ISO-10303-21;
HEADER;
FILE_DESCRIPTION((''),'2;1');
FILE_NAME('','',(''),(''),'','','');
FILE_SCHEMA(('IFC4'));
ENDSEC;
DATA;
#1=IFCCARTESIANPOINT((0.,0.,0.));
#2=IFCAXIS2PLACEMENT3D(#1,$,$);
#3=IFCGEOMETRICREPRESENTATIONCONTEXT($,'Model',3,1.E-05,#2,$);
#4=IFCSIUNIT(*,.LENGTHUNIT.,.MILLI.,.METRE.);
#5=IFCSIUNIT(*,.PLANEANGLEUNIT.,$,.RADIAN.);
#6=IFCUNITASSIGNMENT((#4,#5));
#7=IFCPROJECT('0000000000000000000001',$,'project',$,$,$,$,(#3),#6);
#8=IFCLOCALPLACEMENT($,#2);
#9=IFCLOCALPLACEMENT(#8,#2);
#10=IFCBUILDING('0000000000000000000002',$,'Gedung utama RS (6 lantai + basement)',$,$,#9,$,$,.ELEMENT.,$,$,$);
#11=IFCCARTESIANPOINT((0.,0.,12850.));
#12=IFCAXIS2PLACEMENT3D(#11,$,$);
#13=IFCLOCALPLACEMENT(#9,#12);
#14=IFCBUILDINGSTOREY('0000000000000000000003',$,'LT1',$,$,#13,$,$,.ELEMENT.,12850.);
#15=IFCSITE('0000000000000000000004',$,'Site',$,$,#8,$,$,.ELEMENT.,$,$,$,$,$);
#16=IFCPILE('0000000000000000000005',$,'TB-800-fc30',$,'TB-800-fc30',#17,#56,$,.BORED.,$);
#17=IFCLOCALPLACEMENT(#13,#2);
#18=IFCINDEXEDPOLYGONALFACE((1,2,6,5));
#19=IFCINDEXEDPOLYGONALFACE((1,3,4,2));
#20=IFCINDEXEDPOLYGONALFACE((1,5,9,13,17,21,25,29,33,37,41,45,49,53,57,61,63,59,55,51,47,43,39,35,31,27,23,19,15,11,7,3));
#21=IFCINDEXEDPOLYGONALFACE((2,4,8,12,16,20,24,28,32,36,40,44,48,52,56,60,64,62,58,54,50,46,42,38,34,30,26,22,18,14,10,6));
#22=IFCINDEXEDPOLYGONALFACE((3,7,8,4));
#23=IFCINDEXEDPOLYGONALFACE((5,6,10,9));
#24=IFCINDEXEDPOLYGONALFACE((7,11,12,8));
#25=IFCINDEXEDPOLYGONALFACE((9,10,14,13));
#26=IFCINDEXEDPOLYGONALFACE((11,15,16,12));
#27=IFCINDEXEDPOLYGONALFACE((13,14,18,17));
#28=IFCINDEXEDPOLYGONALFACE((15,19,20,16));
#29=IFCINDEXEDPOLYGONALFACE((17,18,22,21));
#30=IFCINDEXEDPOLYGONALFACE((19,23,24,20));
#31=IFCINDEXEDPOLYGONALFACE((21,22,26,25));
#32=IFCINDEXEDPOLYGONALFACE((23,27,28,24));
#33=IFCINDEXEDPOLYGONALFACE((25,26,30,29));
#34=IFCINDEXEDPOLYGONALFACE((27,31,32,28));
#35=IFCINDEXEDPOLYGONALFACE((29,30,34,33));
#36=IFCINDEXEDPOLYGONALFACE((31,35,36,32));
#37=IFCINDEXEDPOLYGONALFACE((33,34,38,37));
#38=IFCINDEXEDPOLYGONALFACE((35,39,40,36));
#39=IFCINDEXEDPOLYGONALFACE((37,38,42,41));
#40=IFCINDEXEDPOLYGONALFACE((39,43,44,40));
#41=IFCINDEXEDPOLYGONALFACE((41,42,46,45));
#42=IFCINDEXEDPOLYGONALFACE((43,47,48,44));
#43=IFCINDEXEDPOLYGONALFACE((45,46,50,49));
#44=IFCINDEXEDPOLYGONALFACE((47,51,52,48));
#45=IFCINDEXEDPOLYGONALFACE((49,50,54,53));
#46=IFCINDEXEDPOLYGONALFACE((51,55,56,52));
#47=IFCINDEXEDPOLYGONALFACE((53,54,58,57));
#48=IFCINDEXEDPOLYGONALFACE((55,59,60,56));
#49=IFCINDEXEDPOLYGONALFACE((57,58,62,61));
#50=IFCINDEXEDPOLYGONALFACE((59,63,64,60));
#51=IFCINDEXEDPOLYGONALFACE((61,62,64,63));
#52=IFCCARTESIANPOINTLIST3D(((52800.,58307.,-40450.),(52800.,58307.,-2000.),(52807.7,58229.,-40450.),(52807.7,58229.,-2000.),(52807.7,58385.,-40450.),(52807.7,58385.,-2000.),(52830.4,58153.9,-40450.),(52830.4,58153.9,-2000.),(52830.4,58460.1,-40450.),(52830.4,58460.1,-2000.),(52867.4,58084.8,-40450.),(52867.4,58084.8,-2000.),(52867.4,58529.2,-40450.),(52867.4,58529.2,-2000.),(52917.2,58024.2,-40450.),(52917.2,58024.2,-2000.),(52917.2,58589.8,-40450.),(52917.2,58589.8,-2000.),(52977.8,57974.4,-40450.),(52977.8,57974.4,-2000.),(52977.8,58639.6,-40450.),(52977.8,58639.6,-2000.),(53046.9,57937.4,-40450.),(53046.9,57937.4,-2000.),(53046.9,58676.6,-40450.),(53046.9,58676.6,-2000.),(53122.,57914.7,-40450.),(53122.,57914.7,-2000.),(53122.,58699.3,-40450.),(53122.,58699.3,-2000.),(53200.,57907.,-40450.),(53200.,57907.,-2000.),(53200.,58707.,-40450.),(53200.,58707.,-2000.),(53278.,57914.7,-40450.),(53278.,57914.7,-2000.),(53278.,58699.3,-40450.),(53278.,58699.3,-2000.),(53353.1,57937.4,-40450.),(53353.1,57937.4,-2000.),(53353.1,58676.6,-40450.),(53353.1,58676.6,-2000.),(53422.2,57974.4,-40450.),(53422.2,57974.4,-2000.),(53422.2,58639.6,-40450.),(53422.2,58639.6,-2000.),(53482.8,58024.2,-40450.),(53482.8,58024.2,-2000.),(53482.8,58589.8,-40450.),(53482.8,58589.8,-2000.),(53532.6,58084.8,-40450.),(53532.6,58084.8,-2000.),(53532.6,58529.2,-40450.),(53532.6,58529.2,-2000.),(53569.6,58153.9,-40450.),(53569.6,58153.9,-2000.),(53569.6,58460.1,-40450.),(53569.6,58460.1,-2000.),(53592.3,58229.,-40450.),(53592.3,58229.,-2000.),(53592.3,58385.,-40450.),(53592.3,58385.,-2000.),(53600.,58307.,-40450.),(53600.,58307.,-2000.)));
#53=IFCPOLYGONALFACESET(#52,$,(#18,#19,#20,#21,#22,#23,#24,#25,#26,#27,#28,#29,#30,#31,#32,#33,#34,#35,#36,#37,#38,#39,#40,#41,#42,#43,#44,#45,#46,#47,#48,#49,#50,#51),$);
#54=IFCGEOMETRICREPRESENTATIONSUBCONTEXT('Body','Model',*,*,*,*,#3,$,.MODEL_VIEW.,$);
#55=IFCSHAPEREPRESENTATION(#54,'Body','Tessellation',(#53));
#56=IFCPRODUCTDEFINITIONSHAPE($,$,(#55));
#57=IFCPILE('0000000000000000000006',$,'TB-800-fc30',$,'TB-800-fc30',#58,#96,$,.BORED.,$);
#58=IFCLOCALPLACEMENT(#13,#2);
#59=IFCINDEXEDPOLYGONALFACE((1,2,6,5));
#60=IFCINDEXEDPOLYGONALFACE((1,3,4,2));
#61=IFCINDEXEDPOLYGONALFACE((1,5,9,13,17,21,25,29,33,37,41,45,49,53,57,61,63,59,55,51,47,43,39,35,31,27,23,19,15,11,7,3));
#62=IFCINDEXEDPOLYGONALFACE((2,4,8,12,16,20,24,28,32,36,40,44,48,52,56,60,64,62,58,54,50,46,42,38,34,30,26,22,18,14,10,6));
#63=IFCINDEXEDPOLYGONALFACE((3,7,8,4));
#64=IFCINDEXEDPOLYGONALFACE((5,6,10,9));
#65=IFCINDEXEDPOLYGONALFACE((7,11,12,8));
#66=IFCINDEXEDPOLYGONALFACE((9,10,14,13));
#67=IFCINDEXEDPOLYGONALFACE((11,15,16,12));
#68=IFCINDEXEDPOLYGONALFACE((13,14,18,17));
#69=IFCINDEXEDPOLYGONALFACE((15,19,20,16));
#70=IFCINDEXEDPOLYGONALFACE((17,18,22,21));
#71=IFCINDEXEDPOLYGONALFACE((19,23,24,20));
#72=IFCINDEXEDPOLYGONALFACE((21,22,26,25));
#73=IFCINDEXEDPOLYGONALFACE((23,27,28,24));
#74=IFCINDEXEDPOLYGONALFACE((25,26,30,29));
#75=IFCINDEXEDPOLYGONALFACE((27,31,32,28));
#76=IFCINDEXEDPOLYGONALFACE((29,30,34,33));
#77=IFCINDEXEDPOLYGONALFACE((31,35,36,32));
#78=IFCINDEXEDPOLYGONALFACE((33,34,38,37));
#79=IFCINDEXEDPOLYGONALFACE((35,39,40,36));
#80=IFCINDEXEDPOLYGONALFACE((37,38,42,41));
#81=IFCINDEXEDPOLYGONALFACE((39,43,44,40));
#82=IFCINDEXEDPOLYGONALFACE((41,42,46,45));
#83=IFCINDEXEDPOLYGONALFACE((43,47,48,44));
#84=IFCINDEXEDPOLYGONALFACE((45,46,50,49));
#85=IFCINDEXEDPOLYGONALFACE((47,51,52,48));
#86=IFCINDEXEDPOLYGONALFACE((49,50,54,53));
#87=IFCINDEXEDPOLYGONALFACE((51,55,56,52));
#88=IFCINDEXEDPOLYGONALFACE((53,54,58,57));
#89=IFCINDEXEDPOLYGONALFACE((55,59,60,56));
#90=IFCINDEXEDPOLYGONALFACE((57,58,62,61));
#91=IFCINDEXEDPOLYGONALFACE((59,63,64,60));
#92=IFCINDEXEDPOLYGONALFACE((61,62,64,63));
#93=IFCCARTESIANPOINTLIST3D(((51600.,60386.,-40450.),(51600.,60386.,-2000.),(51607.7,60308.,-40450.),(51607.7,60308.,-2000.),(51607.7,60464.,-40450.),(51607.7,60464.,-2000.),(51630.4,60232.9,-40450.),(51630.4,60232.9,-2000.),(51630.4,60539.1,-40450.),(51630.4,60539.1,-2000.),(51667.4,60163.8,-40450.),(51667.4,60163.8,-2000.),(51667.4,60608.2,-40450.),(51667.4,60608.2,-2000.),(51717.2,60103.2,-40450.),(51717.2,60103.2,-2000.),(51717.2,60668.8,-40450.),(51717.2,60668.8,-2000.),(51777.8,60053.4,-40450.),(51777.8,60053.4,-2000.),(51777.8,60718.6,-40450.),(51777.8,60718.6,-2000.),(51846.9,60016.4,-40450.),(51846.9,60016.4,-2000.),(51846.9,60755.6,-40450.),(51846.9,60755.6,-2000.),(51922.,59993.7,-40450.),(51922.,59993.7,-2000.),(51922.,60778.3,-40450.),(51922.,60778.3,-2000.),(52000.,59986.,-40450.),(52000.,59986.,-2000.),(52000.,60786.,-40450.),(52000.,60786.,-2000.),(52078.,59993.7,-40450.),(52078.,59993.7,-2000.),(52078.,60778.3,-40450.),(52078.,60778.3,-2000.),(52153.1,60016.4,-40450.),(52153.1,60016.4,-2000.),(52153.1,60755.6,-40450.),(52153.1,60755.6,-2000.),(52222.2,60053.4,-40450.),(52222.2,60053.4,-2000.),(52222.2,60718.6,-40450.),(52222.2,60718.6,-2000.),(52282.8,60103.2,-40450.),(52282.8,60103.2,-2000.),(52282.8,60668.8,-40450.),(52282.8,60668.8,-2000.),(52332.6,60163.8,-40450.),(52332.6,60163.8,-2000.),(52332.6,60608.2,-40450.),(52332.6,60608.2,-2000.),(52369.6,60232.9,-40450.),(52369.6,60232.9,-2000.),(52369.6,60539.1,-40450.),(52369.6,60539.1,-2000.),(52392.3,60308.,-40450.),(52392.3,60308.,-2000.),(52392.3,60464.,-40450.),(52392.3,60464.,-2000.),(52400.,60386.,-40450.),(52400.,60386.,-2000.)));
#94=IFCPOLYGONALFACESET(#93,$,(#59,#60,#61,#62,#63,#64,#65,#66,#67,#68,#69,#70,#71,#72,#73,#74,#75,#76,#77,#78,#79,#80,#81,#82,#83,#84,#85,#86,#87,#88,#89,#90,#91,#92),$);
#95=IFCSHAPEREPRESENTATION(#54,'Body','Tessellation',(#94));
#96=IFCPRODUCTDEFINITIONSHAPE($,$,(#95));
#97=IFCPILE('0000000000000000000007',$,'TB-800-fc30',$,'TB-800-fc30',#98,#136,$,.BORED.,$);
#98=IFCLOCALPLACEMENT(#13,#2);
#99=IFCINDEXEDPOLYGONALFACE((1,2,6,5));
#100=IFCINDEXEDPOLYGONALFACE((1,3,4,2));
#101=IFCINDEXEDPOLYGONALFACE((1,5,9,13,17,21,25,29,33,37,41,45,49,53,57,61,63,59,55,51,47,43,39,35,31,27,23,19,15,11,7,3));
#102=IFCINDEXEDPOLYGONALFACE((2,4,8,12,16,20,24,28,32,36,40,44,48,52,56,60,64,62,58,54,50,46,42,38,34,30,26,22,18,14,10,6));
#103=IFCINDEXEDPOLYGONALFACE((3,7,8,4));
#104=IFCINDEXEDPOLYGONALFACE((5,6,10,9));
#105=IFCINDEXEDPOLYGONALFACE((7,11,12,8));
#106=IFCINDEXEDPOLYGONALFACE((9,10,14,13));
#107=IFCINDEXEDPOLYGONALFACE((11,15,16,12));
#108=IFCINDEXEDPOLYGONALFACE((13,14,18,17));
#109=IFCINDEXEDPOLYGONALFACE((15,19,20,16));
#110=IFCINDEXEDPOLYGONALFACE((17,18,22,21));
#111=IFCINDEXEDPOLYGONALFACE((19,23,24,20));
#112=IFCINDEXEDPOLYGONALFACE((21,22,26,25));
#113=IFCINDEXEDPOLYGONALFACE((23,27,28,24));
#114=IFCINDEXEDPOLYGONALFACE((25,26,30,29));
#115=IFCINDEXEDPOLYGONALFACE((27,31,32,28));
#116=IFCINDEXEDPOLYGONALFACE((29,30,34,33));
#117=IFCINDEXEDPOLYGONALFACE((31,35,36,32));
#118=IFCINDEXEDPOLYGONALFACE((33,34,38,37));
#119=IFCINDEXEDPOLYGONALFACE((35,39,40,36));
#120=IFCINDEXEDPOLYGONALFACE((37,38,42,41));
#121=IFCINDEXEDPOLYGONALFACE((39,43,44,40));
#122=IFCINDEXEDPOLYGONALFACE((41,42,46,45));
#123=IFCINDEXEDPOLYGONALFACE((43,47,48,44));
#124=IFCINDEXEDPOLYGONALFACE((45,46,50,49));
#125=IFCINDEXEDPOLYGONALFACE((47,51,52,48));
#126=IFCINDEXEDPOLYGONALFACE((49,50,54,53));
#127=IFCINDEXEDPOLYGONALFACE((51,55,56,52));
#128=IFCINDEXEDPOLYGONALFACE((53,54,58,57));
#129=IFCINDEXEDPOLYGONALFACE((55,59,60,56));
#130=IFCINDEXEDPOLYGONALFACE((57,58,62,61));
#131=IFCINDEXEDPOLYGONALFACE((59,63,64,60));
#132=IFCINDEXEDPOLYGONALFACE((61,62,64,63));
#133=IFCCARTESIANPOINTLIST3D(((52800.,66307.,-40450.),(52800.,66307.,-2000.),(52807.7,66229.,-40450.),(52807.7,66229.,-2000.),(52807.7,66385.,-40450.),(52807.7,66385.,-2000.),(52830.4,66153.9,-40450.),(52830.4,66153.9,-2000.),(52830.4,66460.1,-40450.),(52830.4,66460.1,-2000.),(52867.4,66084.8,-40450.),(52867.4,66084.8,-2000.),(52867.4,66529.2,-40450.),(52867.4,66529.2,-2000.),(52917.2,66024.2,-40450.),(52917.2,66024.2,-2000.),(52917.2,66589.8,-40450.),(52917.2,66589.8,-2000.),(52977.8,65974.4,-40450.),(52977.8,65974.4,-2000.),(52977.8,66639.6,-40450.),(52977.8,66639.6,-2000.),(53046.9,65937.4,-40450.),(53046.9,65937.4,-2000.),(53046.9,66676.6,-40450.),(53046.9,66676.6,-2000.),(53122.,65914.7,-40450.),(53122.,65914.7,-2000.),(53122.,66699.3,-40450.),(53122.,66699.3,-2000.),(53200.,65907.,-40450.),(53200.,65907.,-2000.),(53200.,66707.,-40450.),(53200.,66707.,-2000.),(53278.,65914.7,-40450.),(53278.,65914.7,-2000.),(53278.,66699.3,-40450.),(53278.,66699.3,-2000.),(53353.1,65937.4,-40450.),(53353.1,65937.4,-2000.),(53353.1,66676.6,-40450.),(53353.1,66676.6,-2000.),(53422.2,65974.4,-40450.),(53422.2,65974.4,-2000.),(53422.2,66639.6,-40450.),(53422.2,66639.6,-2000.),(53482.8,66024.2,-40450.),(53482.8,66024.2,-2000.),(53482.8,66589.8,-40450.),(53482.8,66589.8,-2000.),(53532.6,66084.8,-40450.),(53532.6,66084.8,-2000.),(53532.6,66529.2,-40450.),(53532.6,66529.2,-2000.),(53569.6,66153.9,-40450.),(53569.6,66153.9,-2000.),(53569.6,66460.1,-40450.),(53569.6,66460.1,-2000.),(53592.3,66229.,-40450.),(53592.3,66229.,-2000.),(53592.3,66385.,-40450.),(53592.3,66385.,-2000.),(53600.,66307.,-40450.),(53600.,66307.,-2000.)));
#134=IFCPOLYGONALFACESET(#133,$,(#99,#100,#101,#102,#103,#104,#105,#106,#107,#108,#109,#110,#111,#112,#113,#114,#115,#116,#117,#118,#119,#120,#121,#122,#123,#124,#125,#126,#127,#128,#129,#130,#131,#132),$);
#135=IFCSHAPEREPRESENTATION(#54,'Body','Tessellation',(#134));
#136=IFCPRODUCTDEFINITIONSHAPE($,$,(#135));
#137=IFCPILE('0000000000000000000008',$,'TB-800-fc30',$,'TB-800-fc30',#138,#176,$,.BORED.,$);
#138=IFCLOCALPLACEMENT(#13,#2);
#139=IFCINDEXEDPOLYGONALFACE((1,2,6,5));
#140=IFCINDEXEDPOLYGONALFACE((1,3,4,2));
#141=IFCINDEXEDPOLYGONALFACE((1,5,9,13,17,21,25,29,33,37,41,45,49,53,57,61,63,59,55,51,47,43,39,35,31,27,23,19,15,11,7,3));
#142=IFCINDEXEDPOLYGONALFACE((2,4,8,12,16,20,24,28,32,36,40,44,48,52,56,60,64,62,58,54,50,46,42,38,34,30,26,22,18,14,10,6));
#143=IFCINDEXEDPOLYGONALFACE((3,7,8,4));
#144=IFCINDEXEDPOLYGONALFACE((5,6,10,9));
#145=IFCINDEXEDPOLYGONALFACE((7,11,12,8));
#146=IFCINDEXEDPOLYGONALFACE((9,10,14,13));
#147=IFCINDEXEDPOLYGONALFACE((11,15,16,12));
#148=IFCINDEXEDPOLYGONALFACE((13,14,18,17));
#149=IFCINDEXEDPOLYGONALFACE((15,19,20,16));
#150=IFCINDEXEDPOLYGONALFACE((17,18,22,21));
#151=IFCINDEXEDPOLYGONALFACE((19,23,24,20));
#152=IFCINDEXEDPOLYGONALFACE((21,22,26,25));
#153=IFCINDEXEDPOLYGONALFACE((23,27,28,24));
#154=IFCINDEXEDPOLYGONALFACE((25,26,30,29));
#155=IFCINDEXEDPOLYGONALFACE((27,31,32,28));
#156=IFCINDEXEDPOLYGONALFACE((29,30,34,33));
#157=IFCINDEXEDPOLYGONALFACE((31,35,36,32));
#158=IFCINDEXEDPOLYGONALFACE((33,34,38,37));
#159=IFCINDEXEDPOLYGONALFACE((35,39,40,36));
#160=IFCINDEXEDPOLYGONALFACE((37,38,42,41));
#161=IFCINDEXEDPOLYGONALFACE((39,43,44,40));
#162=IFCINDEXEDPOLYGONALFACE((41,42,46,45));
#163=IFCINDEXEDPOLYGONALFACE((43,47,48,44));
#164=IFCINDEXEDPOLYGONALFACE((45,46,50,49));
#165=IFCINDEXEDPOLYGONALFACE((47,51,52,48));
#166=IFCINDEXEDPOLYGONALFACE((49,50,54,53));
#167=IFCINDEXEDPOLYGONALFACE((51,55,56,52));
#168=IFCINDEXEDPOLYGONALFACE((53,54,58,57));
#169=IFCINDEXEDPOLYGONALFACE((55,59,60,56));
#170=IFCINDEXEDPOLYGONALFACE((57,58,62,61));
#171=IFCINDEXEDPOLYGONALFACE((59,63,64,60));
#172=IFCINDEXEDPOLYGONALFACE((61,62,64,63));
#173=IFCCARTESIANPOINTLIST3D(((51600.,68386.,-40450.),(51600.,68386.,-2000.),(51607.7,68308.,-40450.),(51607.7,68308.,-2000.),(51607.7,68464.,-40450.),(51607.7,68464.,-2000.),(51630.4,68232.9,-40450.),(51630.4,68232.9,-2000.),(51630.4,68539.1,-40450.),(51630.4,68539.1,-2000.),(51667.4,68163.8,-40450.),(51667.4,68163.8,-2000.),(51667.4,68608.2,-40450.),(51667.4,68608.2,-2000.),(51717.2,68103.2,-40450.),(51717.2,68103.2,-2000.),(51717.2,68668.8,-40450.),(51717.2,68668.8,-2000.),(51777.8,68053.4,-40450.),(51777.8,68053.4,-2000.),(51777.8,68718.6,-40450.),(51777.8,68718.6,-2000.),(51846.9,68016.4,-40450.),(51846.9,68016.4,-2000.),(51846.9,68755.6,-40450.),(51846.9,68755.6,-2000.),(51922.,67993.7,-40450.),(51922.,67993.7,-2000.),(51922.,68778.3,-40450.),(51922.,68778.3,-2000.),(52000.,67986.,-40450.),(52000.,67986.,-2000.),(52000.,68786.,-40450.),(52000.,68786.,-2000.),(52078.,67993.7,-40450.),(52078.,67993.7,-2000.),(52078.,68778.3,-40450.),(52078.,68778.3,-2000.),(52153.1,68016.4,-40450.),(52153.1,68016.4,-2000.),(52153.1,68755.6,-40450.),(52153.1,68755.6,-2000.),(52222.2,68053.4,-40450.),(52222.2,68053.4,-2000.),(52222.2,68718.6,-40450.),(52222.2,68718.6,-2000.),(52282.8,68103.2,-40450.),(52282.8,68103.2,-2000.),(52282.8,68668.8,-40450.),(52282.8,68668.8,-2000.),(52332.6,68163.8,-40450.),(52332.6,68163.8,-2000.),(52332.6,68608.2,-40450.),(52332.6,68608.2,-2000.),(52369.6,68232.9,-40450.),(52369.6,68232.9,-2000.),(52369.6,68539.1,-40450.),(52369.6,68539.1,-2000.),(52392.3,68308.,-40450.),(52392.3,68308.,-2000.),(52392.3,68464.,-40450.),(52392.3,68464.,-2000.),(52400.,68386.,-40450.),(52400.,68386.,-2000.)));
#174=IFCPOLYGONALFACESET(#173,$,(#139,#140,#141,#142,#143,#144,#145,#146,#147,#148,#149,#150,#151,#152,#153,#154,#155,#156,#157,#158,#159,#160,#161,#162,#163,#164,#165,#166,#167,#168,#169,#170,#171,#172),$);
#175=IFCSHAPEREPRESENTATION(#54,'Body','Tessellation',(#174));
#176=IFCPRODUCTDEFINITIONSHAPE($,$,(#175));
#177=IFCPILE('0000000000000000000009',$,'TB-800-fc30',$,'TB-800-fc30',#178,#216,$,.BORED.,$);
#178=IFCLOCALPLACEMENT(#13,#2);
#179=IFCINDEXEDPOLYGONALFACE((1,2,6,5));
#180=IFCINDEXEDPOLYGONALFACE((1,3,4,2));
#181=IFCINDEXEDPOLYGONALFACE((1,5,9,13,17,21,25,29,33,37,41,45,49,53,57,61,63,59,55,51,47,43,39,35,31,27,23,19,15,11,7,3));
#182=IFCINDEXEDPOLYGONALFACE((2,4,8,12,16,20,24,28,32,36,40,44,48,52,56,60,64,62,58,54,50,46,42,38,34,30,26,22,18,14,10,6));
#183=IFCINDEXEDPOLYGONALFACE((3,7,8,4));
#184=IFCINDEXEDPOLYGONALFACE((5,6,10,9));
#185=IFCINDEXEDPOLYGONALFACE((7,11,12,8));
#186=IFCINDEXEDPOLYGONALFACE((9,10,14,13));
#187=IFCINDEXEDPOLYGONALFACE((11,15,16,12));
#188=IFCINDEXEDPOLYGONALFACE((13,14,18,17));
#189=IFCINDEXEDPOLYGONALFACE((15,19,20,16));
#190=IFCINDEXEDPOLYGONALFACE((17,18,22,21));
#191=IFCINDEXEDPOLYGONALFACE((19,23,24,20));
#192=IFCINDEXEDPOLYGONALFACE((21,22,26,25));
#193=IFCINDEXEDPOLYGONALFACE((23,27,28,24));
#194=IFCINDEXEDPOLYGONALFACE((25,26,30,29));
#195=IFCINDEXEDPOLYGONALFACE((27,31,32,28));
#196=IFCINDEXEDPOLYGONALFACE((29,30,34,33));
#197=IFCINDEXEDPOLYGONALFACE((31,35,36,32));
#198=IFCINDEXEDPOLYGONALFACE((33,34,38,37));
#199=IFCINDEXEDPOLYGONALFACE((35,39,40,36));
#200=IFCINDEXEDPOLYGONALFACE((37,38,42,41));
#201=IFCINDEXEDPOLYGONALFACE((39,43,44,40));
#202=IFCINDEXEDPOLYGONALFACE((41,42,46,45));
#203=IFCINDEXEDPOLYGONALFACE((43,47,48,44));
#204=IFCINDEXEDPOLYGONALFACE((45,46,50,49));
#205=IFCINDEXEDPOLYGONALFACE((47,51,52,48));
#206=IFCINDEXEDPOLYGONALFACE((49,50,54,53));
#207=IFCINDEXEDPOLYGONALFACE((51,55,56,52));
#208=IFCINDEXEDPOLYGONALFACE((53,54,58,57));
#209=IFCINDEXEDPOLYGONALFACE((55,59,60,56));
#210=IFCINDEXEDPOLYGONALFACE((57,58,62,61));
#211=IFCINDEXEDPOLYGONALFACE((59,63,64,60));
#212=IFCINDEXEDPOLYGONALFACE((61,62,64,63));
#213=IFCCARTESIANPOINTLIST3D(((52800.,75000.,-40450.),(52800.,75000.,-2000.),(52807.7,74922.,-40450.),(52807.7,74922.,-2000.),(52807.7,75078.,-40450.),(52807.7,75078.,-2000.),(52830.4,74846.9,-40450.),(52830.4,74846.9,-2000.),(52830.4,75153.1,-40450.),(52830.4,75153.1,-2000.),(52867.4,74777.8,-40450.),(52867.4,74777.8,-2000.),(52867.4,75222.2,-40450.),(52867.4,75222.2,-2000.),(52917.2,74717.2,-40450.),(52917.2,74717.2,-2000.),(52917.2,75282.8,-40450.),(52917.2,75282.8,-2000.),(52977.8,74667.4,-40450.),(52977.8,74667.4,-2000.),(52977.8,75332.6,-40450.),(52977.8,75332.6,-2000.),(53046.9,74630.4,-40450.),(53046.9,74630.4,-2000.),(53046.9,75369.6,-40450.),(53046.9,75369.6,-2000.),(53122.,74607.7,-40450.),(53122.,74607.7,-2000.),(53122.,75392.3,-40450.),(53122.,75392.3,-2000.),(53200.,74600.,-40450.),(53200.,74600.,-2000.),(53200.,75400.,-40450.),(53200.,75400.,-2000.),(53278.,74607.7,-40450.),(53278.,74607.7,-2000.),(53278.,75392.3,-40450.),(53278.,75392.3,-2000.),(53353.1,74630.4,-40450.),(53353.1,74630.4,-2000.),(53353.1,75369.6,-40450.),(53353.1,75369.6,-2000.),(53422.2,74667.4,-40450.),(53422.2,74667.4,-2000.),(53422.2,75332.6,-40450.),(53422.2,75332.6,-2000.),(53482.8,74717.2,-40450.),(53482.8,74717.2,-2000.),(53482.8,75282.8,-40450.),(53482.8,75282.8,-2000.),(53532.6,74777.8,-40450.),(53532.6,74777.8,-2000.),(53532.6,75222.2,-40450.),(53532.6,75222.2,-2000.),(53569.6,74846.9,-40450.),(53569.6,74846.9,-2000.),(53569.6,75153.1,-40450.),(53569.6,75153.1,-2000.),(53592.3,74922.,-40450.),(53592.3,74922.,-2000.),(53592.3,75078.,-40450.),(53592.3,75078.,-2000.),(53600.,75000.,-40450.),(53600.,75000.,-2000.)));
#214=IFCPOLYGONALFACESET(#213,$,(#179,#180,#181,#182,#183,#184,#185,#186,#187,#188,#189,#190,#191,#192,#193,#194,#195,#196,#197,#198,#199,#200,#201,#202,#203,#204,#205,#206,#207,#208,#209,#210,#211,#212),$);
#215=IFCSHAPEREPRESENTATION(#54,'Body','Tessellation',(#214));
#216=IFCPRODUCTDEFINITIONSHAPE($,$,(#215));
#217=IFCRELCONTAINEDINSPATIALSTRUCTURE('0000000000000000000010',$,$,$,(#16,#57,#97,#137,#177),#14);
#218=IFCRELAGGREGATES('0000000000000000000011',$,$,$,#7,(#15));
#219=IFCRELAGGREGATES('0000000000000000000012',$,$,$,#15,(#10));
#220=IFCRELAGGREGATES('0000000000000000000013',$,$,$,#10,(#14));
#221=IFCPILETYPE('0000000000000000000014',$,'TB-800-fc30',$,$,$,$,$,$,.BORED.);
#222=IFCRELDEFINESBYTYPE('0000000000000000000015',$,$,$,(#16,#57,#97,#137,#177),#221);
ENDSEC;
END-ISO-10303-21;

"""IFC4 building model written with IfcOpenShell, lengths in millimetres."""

from ifc_helpers import new_model, si_unit, frame, origin, origin_2d, place, context, subcontext, project, spatial, circle, extrude, material_profile, profile_set, profile_usage, type_object, element, save


model = new_model("IFC4")

# Units and contexts
model_context = context("Model", 3, precision=1e-05, world=origin())
body_context = subcontext(model_context, "Body", "Model", "MODEL_VIEW")
ifc_project = project(units=[si_unit("LENGTHUNIT", "METRE", prefix="MILLI"), si_unit("PLANEANGLEUNIT", "RADIAN")], contexts=[model_context])

# Site, building, storey
site_placement = place(None, origin())
site = spatial("IfcSite", under=ifc_project, at=site_placement, Name="Site", CompositionType="ELEMENT")
building_placement = place(site_placement, origin())
building = spatial("IfcBuilding", under=site, at=building_placement, Name="Gedung utama RS (6 lantai + basement)", CompositionType="ELEMENT")
storey_placement = place(building_placement, frame((0.0, 0.0, 12850.0)))
storey = spatial("IfcBuildingStorey", under=building, at=storey_placement, Name="LT1", CompositionType="ELEMENT", Elevation=12850.0)

# Piles
ifc_material_profile_1 = material_profile(None, circle(Radius=400.0, at=origin_2d()), Name="TB-800-fc30")
ifc_profile_set_1 = profile_set([ifc_material_profile_1], Name="TB-800-fc30")
ifc_profile_usage_1 = profile_usage(ifc_profile_set_1, cardinal=5)
pile_type = type_object("IfcPileType", Name="TB-800-fc30", PredefinedType="BORED", material=ifc_profile_set_1)
for number, where, z_axis, x_axis, name in (
    (1, (53200.0, 58307.0, -40450.0), (0.0, 0.0, 1.0), (1.0, 0.0, 0.0), "TB-800-fc30"),
    (2, (52000.0, 60386.0, -40450.0), (0.0, 0.0, 1.0), (1.0, 0.0, 0.0), "TB-800-fc30"),
    (3, (53200.0, 66307.0, -40450.0), (0.0, 0.0, 1.0), (1.0, 0.0, 0.0), "TB-800-fc30"),
    (4, (52000.0, 68386.0, -40450.0), (0.0, 0.0, 1.0), (1.0, 0.0, 0.0), "TB-800-fc30"),
    (5, (53200.0, 75000.0, -40450.0), (0.0, 0.0, 1.0), (1.0, 0.0, 0.0), "TB-800-fc30"),
):
    element("IfcPile", number, at=place(storey_placement, frame(where, z_axis=z_axis, x_axis=x_axis)), inside=storey, type_object=pile_type, material=ifc_profile_usage_1, Name=name, ObjectType="TB-800-fc30", PredefinedType="BORED", context=body_context, shape_type="SweptSolid", body=[
        extrude(circle(Radius=400.0, at=origin_2d()), origin(), (0.0, 0.0, 1.0), 38450.0),
    ])

save(model, "model.ifc")
